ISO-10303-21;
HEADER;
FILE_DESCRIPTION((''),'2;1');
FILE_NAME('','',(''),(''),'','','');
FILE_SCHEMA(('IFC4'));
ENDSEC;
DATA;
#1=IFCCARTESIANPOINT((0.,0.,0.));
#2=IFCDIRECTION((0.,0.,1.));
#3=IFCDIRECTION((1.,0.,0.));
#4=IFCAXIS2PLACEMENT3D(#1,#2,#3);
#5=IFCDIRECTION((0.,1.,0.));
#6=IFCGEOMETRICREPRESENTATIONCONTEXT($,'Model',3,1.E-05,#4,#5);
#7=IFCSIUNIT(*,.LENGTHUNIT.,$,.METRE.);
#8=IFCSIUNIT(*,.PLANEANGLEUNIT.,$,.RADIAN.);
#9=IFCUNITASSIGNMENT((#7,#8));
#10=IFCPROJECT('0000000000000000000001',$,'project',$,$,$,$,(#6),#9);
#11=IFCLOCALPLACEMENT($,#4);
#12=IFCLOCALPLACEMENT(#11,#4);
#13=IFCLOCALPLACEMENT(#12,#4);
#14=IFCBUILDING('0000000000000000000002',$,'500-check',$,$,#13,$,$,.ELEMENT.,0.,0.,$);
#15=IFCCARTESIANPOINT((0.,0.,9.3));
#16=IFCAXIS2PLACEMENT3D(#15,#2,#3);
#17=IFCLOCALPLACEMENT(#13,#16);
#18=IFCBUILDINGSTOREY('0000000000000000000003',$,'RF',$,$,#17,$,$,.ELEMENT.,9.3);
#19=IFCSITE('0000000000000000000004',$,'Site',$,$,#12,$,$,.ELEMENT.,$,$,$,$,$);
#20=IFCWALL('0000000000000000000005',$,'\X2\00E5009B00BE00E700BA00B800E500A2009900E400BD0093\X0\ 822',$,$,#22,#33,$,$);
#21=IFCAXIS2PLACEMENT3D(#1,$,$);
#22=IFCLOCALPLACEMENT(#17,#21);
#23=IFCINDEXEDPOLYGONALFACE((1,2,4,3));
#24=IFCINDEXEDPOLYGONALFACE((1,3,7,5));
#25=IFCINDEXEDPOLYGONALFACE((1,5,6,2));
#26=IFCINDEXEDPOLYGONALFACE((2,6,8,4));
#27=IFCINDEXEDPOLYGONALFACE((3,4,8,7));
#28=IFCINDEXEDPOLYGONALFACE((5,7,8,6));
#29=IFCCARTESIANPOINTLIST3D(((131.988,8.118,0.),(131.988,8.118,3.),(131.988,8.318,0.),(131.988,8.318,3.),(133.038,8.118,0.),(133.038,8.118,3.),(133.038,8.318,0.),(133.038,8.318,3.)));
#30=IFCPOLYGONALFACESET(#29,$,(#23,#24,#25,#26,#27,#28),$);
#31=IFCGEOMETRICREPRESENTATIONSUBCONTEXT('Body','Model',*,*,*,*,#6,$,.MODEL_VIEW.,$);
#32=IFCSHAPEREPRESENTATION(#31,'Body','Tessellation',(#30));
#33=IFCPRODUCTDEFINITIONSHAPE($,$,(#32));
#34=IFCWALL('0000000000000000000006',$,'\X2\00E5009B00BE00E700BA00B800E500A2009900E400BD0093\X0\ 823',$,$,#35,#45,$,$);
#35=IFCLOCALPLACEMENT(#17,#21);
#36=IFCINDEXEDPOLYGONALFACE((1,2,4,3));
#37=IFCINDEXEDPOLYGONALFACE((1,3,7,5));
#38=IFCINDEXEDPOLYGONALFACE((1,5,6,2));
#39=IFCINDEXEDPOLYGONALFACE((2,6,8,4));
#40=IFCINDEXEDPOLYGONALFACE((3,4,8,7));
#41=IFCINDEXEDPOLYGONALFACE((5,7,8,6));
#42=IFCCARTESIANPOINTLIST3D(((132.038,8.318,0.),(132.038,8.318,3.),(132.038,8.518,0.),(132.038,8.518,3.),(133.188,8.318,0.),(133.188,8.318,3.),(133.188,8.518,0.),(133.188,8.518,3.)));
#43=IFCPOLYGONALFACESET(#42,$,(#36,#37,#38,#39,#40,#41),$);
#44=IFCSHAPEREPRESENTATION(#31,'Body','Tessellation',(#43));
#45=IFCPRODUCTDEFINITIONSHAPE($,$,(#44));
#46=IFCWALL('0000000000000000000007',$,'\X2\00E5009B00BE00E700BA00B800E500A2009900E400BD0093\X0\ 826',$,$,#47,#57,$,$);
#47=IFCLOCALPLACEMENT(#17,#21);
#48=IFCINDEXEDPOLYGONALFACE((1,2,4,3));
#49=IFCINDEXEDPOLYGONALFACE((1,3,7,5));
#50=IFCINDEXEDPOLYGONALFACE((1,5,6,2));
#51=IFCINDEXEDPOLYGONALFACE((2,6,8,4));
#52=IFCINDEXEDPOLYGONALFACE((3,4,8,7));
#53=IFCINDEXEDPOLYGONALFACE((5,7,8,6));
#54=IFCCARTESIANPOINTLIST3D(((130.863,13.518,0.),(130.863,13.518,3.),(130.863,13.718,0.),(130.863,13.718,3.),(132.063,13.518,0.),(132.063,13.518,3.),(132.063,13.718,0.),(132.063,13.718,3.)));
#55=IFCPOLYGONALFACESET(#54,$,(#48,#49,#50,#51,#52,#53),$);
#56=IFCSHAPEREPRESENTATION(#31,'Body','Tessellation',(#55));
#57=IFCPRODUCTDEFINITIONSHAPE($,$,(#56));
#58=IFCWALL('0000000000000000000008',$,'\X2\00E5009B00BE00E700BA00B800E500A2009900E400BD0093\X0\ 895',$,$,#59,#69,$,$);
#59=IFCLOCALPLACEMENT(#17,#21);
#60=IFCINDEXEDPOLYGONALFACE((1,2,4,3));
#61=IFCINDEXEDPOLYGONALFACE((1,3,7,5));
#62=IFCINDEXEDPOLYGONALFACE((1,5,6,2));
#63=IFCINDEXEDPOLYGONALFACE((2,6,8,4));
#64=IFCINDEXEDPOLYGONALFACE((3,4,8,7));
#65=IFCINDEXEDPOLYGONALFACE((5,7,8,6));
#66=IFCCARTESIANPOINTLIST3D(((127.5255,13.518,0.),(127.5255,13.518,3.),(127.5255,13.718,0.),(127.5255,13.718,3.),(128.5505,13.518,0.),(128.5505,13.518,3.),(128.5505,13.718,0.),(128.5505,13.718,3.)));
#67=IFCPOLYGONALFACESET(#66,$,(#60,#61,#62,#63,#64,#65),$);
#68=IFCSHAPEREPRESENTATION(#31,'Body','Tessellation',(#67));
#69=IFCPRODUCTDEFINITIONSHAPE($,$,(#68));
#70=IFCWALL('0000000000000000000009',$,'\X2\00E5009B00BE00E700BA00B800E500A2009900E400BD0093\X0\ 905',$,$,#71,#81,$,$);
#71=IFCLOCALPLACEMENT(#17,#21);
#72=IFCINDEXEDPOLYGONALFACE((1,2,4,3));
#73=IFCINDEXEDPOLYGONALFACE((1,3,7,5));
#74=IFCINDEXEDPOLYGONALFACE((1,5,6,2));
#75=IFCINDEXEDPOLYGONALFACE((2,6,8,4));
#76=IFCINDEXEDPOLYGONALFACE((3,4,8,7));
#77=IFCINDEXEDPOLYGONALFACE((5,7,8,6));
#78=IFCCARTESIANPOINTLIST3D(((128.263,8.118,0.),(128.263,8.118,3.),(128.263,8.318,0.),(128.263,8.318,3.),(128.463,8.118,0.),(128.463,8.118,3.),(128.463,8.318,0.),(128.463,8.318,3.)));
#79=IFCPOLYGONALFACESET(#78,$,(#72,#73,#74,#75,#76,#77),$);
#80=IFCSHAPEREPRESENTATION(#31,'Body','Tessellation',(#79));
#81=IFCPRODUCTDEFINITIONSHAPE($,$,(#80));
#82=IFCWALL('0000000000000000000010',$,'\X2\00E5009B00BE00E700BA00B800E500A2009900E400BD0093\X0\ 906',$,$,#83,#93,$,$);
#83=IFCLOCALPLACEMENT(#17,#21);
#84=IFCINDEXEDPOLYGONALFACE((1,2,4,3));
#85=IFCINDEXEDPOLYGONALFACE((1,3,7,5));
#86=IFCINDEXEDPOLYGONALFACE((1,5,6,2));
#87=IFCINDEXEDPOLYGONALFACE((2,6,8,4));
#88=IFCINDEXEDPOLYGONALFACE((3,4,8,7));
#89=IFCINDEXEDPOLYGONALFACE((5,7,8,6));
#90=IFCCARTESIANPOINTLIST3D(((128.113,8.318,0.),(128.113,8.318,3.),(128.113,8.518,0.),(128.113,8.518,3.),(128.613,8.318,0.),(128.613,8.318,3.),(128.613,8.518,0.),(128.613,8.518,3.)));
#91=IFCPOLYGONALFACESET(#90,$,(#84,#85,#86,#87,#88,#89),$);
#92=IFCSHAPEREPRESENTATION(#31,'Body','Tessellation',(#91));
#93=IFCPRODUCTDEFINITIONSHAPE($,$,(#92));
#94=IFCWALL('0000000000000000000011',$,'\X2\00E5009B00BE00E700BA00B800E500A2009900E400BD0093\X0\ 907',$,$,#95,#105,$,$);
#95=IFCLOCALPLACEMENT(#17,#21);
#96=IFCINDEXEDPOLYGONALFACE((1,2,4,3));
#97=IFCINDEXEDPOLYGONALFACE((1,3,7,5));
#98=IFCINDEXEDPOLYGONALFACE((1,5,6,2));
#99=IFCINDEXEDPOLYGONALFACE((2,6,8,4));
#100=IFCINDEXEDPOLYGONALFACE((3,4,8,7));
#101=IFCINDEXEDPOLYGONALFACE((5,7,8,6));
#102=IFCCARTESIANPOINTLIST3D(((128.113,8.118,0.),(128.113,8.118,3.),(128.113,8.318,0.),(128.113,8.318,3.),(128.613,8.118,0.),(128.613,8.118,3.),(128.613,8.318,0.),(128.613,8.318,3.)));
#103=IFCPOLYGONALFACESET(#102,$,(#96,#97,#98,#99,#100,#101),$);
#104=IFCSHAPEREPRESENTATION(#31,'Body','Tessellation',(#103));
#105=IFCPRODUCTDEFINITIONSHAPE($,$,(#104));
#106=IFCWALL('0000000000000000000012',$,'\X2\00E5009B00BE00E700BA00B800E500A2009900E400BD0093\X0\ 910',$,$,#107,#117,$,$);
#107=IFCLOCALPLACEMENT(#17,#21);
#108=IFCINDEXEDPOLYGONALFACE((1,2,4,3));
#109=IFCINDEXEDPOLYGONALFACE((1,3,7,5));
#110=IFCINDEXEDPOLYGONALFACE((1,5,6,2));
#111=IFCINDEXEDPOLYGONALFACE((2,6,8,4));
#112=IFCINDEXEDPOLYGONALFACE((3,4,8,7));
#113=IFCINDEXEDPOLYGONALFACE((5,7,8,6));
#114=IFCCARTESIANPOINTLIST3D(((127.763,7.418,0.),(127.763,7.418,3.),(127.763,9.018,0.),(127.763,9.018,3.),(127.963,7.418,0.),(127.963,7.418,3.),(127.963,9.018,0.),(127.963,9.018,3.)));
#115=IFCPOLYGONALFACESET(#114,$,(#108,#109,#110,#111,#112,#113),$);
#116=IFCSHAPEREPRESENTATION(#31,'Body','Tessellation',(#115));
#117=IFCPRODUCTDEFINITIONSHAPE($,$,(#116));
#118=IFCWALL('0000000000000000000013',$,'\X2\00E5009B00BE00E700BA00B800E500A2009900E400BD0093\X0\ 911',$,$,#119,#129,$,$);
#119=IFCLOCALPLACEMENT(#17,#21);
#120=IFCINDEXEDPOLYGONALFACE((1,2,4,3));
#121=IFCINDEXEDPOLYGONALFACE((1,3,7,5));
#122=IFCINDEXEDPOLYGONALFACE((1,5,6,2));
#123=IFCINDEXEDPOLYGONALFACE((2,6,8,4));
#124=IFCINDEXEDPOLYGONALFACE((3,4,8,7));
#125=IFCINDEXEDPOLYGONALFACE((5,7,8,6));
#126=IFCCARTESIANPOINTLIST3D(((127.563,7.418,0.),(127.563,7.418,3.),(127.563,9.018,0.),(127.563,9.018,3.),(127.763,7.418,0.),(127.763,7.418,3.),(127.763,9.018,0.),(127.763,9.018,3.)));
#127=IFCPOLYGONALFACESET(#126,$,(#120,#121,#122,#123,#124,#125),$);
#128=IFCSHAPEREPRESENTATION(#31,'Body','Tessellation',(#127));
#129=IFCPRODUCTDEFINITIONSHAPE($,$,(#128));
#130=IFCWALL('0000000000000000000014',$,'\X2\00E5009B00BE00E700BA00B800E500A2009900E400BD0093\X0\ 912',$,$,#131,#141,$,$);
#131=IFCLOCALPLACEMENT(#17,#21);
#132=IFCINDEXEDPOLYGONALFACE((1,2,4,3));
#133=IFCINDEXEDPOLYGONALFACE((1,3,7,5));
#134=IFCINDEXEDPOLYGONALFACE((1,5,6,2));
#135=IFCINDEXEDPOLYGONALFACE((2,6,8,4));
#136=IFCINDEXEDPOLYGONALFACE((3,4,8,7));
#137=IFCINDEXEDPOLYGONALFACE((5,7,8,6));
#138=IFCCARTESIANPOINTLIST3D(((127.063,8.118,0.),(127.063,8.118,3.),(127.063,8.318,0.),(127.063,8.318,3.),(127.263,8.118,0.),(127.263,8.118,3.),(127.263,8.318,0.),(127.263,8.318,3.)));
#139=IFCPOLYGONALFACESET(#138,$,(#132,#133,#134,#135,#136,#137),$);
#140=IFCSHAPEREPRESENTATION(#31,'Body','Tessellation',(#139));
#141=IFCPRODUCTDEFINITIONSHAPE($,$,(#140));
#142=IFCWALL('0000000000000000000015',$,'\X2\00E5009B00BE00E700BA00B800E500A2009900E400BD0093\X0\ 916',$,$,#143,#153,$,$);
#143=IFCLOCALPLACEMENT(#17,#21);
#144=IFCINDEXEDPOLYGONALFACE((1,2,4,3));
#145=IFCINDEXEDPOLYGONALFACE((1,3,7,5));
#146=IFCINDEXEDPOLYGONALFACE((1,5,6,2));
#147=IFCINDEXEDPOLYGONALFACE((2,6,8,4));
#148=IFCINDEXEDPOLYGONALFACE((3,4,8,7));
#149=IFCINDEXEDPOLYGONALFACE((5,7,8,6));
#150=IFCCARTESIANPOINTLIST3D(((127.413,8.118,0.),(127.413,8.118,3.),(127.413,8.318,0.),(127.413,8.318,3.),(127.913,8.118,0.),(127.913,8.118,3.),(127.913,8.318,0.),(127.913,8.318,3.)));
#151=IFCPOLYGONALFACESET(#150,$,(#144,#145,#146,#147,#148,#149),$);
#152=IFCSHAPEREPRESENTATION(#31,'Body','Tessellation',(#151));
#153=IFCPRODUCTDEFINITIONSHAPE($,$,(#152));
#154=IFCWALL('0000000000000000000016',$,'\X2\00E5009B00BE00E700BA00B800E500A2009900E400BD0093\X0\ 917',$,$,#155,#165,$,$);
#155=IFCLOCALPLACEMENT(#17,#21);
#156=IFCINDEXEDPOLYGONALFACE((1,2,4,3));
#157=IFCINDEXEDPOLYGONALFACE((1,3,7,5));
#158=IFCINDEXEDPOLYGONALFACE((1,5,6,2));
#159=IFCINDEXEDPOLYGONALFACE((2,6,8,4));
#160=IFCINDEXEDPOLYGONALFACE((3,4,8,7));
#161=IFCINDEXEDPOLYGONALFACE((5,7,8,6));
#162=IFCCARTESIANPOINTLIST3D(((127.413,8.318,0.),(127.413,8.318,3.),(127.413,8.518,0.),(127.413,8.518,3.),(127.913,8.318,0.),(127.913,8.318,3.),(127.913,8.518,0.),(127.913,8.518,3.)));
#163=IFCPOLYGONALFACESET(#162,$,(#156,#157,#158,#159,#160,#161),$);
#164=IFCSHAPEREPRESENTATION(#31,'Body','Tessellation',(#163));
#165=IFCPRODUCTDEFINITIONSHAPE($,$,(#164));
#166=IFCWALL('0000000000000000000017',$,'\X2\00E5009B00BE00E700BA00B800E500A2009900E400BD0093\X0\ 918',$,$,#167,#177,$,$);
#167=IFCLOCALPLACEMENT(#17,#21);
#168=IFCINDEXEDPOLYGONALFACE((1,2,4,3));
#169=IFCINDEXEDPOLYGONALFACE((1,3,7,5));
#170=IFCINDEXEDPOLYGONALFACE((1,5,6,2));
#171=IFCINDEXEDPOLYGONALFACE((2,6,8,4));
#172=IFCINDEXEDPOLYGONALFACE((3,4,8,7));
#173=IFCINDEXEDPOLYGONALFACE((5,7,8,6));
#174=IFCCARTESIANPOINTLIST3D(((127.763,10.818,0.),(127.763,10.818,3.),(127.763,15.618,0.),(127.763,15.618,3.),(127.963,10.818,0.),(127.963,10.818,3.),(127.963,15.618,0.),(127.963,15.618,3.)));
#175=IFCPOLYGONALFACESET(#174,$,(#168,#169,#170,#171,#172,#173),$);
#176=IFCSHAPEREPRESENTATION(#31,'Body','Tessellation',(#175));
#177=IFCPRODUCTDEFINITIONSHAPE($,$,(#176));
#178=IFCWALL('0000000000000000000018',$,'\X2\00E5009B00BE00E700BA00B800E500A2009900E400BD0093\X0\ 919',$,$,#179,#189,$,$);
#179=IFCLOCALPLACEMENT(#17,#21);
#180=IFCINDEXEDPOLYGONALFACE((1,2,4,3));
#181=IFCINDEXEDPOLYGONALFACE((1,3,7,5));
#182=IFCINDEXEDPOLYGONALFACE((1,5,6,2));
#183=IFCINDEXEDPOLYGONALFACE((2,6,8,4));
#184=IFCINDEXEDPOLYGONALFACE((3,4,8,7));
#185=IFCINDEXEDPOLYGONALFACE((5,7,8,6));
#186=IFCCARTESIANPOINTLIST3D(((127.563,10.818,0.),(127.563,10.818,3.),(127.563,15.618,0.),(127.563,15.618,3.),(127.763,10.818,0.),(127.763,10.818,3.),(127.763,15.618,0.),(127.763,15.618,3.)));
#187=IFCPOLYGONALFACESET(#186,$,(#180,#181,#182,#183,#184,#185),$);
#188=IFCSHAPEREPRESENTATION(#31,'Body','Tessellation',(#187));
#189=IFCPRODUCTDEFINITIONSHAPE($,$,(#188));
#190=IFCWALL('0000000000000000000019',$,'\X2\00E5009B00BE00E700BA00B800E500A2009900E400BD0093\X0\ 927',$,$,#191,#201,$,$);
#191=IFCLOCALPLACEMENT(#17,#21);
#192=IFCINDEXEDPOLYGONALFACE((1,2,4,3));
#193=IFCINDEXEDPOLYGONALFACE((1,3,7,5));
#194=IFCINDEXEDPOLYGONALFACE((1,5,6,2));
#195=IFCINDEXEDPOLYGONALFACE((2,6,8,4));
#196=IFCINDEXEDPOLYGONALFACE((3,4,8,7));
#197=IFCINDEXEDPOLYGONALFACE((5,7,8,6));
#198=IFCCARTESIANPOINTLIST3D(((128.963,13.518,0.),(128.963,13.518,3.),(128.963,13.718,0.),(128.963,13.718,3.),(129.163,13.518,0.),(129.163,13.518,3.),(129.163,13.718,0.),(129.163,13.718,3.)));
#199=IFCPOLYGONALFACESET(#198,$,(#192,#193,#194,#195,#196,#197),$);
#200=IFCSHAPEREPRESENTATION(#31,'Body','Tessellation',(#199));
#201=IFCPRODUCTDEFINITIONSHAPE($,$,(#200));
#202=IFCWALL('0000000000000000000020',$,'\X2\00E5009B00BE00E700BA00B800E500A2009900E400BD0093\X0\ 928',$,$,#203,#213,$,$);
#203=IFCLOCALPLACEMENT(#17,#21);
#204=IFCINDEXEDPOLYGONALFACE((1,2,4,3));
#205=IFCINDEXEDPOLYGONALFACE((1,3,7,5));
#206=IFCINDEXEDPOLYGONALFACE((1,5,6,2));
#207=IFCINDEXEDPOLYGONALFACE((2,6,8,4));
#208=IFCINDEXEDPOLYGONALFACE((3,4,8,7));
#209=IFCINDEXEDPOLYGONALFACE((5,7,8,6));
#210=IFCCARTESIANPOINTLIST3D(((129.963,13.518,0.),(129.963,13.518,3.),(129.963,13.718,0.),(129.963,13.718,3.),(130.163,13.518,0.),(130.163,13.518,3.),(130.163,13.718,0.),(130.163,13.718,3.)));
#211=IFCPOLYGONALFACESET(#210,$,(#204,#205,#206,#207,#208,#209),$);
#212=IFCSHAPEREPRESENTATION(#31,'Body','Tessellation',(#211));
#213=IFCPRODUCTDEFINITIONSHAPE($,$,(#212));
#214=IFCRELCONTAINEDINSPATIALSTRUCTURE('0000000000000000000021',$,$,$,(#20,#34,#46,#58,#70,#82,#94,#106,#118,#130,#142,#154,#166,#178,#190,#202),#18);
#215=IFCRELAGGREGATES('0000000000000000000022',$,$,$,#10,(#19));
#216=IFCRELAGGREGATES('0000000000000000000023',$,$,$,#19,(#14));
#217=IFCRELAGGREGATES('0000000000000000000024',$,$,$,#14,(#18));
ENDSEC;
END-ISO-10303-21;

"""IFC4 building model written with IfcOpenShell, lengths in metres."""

from ifc_helpers import new_model, si_unit, direction, frame, frame_2d, origin_with_axes, place, context, subcontext, project, spatial, rectangle, extrude, element, save


model = new_model("IFC4")

# Units and contexts
model_context = context("Model", 3, precision=1e-05, world=origin_with_axes(), true_north=direction((0.0, 1.0, 0.0)))
body_context = subcontext(model_context, "Body", "Model", "MODEL_VIEW")
ifc_project = project(units=[si_unit("LENGTHUNIT", "METRE"), si_unit("PLANEANGLEUNIT", "RADIAN")], contexts=[model_context])

# Site, building, storey
placement = place(None, origin_with_axes())
site_placement = place(placement, origin_with_axes())
site = spatial("IfcSite", under=ifc_project, at=site_placement, Name="Site", CompositionType="ELEMENT")
building_placement = place(site_placement, origin_with_axes())
building = spatial("IfcBuilding", under=site, at=building_placement, Name="500-check", CompositionType="ELEMENT", ElevationOfRefHeight=0.0, ElevationOfTerrain=0.0)
storey_placement = place(building_placement, frame((0.0, 0.0, 9.3), z_axis=(0.0, 0.0, 1.0), x_axis=(1.0, 0.0, 0.0)))
storey = spatial("IfcBuildingStorey", under=building, at=storey_placement, Name="RF", CompositionType="ELEMENT", Elevation=9.3)

# Walls
wall_1_placement = place(storey_placement, frame((132.513, 8.218, 0.0), z_axis=(0.0, 0.0, 1.0), x_axis=(-1.0, 0.0, 0.0)))
element("IfcWall", 1, at=wall_1_placement, inside=storey, Name="å\u009b¾çº¸å¢\u0099ä½\u0093 822", context=body_context, shape_type="SweptSolid", body=[
    extrude(rectangle(XDim=1.05, YDim=0.2, at=frame_2d((0.0, 0.0), x_axis=(1.0, 0.0, 0.0))), frame((0.0, 0.0, 0.0), z_axis=(0.0, 0.0, 1.0)), (0.0, 0.0, 1.0), 3.0),
])
wall_2_placement = place(storey_placement, frame((132.613, 8.418, 0.0), z_axis=(0.0, 0.0, 1.0), x_axis=(-1.0, 0.0, 0.0)))
element("IfcWall", 2, at=wall_2_placement, inside=storey, Name="å\u009b¾çº¸å¢\u0099ä½\u0093 823", context=body_context, shape_type="SweptSolid", body=[
    extrude(rectangle(XDim=1.15, YDim=0.2, at=frame_2d((0.0, 0.0), x_axis=(1.0, 0.0, 0.0))), frame((0.0, 0.0, 0.0), z_axis=(0.0, 0.0, 1.0)), (0.0, 0.0, 1.0), 3.0),
])
wall_3_placement = place(storey_placement, frame((131.463, 13.618, 0.0), z_axis=(0.0, 0.0, 1.0), x_axis=(1.0, 0.0, 0.0)))
element("IfcWall", 3, at=wall_3_placement, inside=storey, Name="å\u009b¾çº¸å¢\u0099ä½\u0093 826", context=body_context, shape_type="SweptSolid", body=[
    extrude(rectangle(XDim=1.2, YDim=0.2, at=frame_2d((0.0, 0.0), x_axis=(1.0, 0.0, 0.0))), frame((0.0, 0.0, 0.0), z_axis=(0.0, 0.0, 1.0)), (0.0, 0.0, 1.0), 3.0),
])
wall_4_placement = place(storey_placement, frame((128.038, 13.618, 0.0), z_axis=(0.0, 0.0, 1.0), x_axis=(1.0, 0.0, 0.0)))
element("IfcWall", 4, at=wall_4_placement, inside=storey, Name="å\u009b¾çº¸å¢\u0099ä½\u0093 895", context=body_context, shape_type="SweptSolid", body=[
    extrude(rectangle(XDim=1.025, YDim=0.2, at=frame_2d((0.0, 0.0), x_axis=(1.0, 0.0, 0.0))), frame((0.0, 0.0, 0.0), z_axis=(0.0, 0.0, 1.0)), (0.0, 0.0, 1.0), 3.0),
])
wall_5_placement = place(storey_placement, frame((128.363, 8.218, 0.0), z_axis=(0.0, 0.0, 1.0), x_axis=(0.0, 1.0, 0.0)))
element("IfcWall", 5, at=wall_5_placement, inside=storey, Name="å\u009b¾çº¸å¢\u0099ä½\u0093 905", context=body_context, shape_type="SweptSolid", body=[
    extrude(rectangle(XDim=0.2, YDim=0.2, at=frame_2d((0.0, 0.0), x_axis=(1.0, 0.0, 0.0))), frame((0.0, 0.0, 0.0), z_axis=(0.0, 0.0, 1.0)), (0.0, 0.0, 1.0), 3.0),
])
for number, where, z_axis, x_axis, name in (
    (6, (128.363, 8.418, 0.0), (0.0, 0.0, 1.0), (-1.0, 0.0, 0.0), "å\u009b¾çº¸å¢\u0099ä½\u0093 906"),
    (7, (128.363, 8.218, 0.0), (0.0, 0.0, 1.0), (-1.0, 0.0, 0.0), "å\u009b¾çº¸å¢\u0099ä½\u0093 907"),
):
    element("IfcWall", number, at=place(storey_placement, frame(where, z_axis=z_axis, x_axis=x_axis)), inside=storey, Name=name, context=body_context, shape_type="SweptSolid", body=[
        extrude(rectangle(XDim=0.5, YDim=0.2, at=frame_2d((0.0, 0.0), x_axis=(1.0, 0.0, 0.0))), frame((0.0, 0.0, 0.0), z_axis=(0.0, 0.0, 1.0)), (0.0, 0.0, 1.0), 3.0),
    ])
for number, where, z_axis, x_axis, name in (
    (8, (127.863, 8.218, 0.0), (0.0, 0.0, 1.0), (0.0, -1.0, 0.0), "å\u009b¾çº¸å¢\u0099ä½\u0093 910"),
    (9, (127.663, 8.218, 0.0), (0.0, 0.0, 1.0), (0.0, -1.0, 0.0), "å\u009b¾çº¸å¢\u0099ä½\u0093 911"),
):
    element("IfcWall", number, at=place(storey_placement, frame(where, z_axis=z_axis, x_axis=x_axis)), inside=storey, Name=name, context=body_context, shape_type="SweptSolid", body=[
        extrude(rectangle(XDim=1.6, YDim=0.2, at=frame_2d((0.0, 0.0), x_axis=(1.0, 0.0, 0.0))), frame((0.0, 0.0, 0.0), z_axis=(0.0, 0.0, 1.0)), (0.0, 0.0, 1.0), 3.0),
    ])
wall_6_placement = place(storey_placement, frame((127.163, 8.218, 0.0), z_axis=(0.0, 0.0, 1.0), x_axis=(0.0, 1.0, 0.0)))
element("IfcWall", 10, at=wall_6_placement, inside=storey, Name="å\u009b¾çº¸å¢\u0099ä½\u0093 912", context=body_context, shape_type="SweptSolid", body=[
    extrude(rectangle(XDim=0.2, YDim=0.2, at=frame_2d((0.0, 0.0), x_axis=(1.0, 0.0, 0.0))), frame((0.0, 0.0, 0.0), z_axis=(0.0, 0.0, 1.0)), (0.0, 0.0, 1.0), 3.0),
])
for number, where, z_axis, x_axis, name in (
    (11, (127.663, 8.218, 0.0), (0.0, 0.0, 1.0), (-1.0, 0.0, 0.0), "å\u009b¾çº¸å¢\u0099ä½\u0093 916"),
    (12, (127.663, 8.418, 0.0), (0.0, 0.0, 1.0), (-1.0, 0.0, 0.0), "å\u009b¾çº¸å¢\u0099ä½\u0093 917"),
):
    element("IfcWall", number, at=place(storey_placement, frame(where, z_axis=z_axis, x_axis=x_axis)), inside=storey, Name=name, context=body_context, shape_type="SweptSolid", body=[
        extrude(rectangle(XDim=0.5, YDim=0.2, at=frame_2d((0.0, 0.0), x_axis=(1.0, 0.0, 0.0))), frame((0.0, 0.0, 0.0), z_axis=(0.0, 0.0, 1.0)), (0.0, 0.0, 1.0), 3.0),
    ])
for number, where, z_axis, x_axis, name in (
    (13, (127.863, 13.218, 0.0), (0.0, 0.0, 1.0), (0.0, -1.0, 0.0), "å\u009b¾çº¸å¢\u0099ä½\u0093 918"),
    (14, (127.663, 13.218, 0.0), (0.0, 0.0, 1.0), (0.0, -1.0, 0.0), "å\u009b¾çº¸å¢\u0099ä½\u0093 919"),
):
    element("IfcWall", number, at=place(storey_placement, frame(where, z_axis=z_axis, x_axis=x_axis)), inside=storey, Name=name, context=body_context, shape_type="SweptSolid", body=[
        extrude(rectangle(XDim=4.8, YDim=0.2, at=frame_2d((0.0, 0.0), x_axis=(1.0, 0.0, 0.0))), frame((0.0, 0.0, 0.0), z_axis=(0.0, 0.0, 1.0)), (0.0, 0.0, 1.0), 3.0),
    ])
for number, where, z_axis, x_axis, name in (
    (15, (129.063, 13.618, 0.0), (0.0, 0.0, 1.0), (0.0, 1.0, 0.0), "å\u009b¾çº¸å¢\u0099ä½\u0093 927"),
    (16, (130.063, 13.618, 0.0), (0.0, 0.0, 1.0), (0.0, 1.0, 0.0), "å\u009b¾çº¸å¢\u0099ä½\u0093 928"),
):
    element("IfcWall", number, at=place(storey_placement, frame(where, z_axis=z_axis, x_axis=x_axis)), inside=storey, Name=name, context=body_context, shape_type="SweptSolid", body=[
        extrude(rectangle(XDim=0.2, YDim=0.2, at=frame_2d((0.0, 0.0), x_axis=(1.0, 0.0, 0.0))), frame((0.0, 0.0, 0.0), z_axis=(0.0, 0.0, 1.0)), (0.0, 0.0, 1.0), 3.0),
    ])

save(model, "model.ifc")
